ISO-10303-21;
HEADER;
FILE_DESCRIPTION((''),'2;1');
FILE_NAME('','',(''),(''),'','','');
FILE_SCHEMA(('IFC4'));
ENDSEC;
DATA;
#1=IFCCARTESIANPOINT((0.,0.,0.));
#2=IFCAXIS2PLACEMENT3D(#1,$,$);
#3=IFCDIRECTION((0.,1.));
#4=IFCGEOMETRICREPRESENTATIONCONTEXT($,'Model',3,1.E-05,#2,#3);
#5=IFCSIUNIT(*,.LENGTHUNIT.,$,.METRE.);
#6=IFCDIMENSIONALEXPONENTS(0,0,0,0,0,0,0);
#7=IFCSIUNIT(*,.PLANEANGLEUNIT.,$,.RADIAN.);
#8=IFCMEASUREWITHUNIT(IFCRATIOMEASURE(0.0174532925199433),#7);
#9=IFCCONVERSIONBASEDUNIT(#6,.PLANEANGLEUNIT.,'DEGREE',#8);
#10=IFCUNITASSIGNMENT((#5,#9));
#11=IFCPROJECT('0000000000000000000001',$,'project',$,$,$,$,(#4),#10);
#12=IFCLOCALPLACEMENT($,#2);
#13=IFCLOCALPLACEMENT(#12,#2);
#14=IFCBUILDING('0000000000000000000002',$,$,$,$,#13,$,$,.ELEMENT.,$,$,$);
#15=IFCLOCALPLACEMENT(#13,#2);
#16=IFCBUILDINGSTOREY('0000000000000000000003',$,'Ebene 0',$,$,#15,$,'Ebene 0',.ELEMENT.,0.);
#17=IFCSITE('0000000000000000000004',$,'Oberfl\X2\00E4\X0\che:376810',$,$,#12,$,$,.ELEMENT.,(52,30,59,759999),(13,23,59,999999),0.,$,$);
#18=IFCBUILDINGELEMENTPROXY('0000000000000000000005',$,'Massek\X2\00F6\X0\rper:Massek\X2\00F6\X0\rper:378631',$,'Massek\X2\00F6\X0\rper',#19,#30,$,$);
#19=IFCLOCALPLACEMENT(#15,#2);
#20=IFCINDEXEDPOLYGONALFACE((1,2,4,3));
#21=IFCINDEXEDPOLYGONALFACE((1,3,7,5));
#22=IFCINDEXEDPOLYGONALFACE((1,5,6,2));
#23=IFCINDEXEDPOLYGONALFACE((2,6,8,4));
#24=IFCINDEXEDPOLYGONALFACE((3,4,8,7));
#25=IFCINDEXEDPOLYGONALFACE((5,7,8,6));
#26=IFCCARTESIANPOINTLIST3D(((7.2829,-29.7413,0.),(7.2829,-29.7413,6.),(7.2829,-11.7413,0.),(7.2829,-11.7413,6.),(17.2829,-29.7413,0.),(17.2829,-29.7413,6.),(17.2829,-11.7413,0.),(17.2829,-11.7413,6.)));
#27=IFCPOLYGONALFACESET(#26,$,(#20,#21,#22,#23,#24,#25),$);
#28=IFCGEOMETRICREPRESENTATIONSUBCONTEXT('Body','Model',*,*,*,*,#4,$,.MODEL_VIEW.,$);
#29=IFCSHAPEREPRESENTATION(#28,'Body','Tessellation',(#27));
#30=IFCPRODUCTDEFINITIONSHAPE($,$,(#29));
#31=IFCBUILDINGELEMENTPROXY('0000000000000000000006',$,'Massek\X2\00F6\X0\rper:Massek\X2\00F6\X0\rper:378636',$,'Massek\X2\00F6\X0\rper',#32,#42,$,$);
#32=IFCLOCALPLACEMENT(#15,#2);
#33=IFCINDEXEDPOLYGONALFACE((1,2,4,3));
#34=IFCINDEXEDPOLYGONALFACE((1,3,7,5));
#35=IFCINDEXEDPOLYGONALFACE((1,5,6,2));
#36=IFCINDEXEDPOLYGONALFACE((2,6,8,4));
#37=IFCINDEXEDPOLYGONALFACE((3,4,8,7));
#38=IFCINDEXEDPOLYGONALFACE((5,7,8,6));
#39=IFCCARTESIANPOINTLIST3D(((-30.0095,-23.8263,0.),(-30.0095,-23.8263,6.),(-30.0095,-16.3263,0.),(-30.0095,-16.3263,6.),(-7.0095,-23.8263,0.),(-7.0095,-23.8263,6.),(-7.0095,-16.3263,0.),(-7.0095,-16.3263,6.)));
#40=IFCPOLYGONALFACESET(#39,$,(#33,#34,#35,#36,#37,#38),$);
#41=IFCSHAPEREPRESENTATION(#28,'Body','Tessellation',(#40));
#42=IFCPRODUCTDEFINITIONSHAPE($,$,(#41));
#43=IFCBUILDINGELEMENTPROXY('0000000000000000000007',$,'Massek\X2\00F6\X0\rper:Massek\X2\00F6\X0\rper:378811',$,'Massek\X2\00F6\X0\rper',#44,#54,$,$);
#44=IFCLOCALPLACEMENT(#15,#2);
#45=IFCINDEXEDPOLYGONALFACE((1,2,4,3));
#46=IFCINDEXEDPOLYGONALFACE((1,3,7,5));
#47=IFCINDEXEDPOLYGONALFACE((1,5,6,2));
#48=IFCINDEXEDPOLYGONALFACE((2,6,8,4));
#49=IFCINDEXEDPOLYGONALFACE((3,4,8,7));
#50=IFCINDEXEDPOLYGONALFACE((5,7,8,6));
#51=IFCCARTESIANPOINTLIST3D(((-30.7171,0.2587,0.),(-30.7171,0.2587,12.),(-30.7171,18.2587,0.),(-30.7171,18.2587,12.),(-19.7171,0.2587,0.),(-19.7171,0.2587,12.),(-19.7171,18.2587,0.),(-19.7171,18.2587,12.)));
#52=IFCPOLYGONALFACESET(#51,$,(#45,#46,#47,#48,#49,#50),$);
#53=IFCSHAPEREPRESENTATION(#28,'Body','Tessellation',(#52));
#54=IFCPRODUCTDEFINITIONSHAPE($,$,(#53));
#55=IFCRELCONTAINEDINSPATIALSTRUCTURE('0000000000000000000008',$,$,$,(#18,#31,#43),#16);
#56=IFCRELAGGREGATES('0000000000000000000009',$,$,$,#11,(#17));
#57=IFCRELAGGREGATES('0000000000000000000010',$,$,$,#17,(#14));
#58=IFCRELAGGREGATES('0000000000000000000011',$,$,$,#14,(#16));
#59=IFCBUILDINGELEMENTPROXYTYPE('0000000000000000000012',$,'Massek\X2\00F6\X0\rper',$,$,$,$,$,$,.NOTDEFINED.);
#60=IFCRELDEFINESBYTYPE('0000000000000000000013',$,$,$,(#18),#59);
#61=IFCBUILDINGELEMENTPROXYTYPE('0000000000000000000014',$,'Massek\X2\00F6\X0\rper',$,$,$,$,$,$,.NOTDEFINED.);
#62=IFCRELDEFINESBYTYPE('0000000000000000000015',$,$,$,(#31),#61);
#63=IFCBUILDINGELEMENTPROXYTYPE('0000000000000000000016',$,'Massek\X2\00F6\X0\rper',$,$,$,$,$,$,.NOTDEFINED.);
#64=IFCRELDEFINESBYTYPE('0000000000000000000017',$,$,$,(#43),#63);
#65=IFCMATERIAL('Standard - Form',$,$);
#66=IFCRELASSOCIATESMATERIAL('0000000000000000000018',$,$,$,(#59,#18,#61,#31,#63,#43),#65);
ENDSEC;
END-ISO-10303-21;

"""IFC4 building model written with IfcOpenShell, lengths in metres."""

from ifc_helpers import new_model, entity, si_unit, converted_unit, direction, frame, origin, origin_2d_with_axis, place, context, subcontext, project, spatial, rectangle, extrude, source, transform, mapped, material, type_object, type_shapes, element, save


model = new_model("IFC4")

# Units and contexts
model_context = context("Model", 3, precision=1e-05, world=origin(), true_north=direction((0.0, 1.0)))
body_context = subcontext(model_context, "Body", "Model", "MODEL_VIEW")
ifc_project = project(units=[si_unit("LENGTHUNIT", "METRE"), converted_unit("PLANEANGLEUNIT", "DEGREE", entity("IfcRatioMeasure", 0.0174532925199433), si_unit("PLANEANGLEUNIT", "RADIAN"), dimensions=[0, 0, 0, 0, 0, 0, 0])], contexts=[model_context])

# Site, building, storey
site_placement = place(None, origin())
site = spatial("IfcSite", under=ifc_project, at=site_placement, Name="Oberfläche:376810", CompositionType="ELEMENT", RefLatitude=(52, 30, 59, 759999), RefLongitude=(13, 23, 59, 999999), RefElevation=0.0)
building_placement = place(site_placement, origin())
building = spatial("IfcBuilding", under=site, at=building_placement, CompositionType="ELEMENT")
storey_placement = place(building_placement, origin())
storey = spatial("IfcBuildingStorey", under=building, at=storey_placement, Name="Ebene 0", LongName="Ebene 0", CompositionType="ELEMENT", Elevation=0.0)

# Building element proxies
ifc_material_1 = material(Name="Standard - Form")
building_element_proxy_type_1 = type_object("IfcBuildingElementProxyType", Name="Massekörper", PredefinedType="NOTDEFINED", material=ifc_material_1)
shared_shape_1 = source(origin(), body_context, "Body", "SweptSolid", [
    extrude(rectangle(XDim=18.0, YDim=10.0, at=origin_2d_with_axis()), frame((5.0, 9.0, 0.0), z_axis=(0.0, 0.0, 1.0), x_axis=(0.0, 1.0, 0.0)), (0.0, 0.0, 1.0), 6.0),
])
type_shapes(building_element_proxy_type_1, [shared_shape_1])
proxy_1_placement = place(storey_placement, frame((7.2829, -29.7413, 0.0)))
element("IfcBuildingElementProxy", 1, at=proxy_1_placement, inside=storey, type_object=building_element_proxy_type_1, material=ifc_material_1, Name="Massekörper:Massekörper:378631", ObjectType="Massekörper", context=body_context, shape_type="MappedRepresentation", body=[
    mapped(shared_shape_1, transform((0.0, 0.0, 0.0), scale=1.0)),
])
building_element_proxy_type_2 = type_object("IfcBuildingElementProxyType", Name="Massekörper", PredefinedType="NOTDEFINED", material=ifc_material_1)
shared_shape_2 = source(origin(), body_context, "Body", "SweptSolid", [
    extrude(rectangle(XDim=7.5, YDim=23.0, at=origin_2d_with_axis()), frame((11.5, 3.75, 0.0), z_axis=(0.0, 0.0, 1.0), x_axis=(0.0, 1.0, 0.0)), (0.0, 0.0, 1.0), 6.0),
])
type_shapes(building_element_proxy_type_2, [shared_shape_2])
proxy_2_placement = place(storey_placement, frame((-30.0095, -23.8263, 0.0)))
element("IfcBuildingElementProxy", 2, at=proxy_2_placement, inside=storey, type_object=building_element_proxy_type_2, material=ifc_material_1, Name="Massekörper:Massekörper:378636", ObjectType="Massekörper", context=body_context, shape_type="MappedRepresentation", body=[
    mapped(shared_shape_2, transform((0.0, 0.0, 0.0), scale=1.0)),
])
building_element_proxy_type_3 = type_object("IfcBuildingElementProxyType", Name="Massekörper", PredefinedType="NOTDEFINED", material=ifc_material_1)
shared_shape_3 = source(origin(), body_context, "Body", "SweptSolid", [
    extrude(rectangle(XDim=18.0, YDim=11.0, at=origin_2d_with_axis()), frame((5.5, 9.0, 0.0), z_axis=(0.0, 0.0, 1.0), x_axis=(0.0, 1.0, 0.0)), (0.0, 0.0, 1.0), 12.0),
])
type_shapes(building_element_proxy_type_3, [shared_shape_3])
proxy_3_placement = place(storey_placement, frame((-30.7171, 0.2587, 0.0)))
element("IfcBuildingElementProxy", 3, at=proxy_3_placement, inside=storey, type_object=building_element_proxy_type_3, material=ifc_material_1, Name="Massekörper:Massekörper:378811", ObjectType="Massekörper", context=body_context, shape_type="MappedRepresentation", body=[
    mapped(shared_shape_3, transform((0.0, 0.0, 0.0), scale=1.0)),
])

save(model, "model.ifc")
